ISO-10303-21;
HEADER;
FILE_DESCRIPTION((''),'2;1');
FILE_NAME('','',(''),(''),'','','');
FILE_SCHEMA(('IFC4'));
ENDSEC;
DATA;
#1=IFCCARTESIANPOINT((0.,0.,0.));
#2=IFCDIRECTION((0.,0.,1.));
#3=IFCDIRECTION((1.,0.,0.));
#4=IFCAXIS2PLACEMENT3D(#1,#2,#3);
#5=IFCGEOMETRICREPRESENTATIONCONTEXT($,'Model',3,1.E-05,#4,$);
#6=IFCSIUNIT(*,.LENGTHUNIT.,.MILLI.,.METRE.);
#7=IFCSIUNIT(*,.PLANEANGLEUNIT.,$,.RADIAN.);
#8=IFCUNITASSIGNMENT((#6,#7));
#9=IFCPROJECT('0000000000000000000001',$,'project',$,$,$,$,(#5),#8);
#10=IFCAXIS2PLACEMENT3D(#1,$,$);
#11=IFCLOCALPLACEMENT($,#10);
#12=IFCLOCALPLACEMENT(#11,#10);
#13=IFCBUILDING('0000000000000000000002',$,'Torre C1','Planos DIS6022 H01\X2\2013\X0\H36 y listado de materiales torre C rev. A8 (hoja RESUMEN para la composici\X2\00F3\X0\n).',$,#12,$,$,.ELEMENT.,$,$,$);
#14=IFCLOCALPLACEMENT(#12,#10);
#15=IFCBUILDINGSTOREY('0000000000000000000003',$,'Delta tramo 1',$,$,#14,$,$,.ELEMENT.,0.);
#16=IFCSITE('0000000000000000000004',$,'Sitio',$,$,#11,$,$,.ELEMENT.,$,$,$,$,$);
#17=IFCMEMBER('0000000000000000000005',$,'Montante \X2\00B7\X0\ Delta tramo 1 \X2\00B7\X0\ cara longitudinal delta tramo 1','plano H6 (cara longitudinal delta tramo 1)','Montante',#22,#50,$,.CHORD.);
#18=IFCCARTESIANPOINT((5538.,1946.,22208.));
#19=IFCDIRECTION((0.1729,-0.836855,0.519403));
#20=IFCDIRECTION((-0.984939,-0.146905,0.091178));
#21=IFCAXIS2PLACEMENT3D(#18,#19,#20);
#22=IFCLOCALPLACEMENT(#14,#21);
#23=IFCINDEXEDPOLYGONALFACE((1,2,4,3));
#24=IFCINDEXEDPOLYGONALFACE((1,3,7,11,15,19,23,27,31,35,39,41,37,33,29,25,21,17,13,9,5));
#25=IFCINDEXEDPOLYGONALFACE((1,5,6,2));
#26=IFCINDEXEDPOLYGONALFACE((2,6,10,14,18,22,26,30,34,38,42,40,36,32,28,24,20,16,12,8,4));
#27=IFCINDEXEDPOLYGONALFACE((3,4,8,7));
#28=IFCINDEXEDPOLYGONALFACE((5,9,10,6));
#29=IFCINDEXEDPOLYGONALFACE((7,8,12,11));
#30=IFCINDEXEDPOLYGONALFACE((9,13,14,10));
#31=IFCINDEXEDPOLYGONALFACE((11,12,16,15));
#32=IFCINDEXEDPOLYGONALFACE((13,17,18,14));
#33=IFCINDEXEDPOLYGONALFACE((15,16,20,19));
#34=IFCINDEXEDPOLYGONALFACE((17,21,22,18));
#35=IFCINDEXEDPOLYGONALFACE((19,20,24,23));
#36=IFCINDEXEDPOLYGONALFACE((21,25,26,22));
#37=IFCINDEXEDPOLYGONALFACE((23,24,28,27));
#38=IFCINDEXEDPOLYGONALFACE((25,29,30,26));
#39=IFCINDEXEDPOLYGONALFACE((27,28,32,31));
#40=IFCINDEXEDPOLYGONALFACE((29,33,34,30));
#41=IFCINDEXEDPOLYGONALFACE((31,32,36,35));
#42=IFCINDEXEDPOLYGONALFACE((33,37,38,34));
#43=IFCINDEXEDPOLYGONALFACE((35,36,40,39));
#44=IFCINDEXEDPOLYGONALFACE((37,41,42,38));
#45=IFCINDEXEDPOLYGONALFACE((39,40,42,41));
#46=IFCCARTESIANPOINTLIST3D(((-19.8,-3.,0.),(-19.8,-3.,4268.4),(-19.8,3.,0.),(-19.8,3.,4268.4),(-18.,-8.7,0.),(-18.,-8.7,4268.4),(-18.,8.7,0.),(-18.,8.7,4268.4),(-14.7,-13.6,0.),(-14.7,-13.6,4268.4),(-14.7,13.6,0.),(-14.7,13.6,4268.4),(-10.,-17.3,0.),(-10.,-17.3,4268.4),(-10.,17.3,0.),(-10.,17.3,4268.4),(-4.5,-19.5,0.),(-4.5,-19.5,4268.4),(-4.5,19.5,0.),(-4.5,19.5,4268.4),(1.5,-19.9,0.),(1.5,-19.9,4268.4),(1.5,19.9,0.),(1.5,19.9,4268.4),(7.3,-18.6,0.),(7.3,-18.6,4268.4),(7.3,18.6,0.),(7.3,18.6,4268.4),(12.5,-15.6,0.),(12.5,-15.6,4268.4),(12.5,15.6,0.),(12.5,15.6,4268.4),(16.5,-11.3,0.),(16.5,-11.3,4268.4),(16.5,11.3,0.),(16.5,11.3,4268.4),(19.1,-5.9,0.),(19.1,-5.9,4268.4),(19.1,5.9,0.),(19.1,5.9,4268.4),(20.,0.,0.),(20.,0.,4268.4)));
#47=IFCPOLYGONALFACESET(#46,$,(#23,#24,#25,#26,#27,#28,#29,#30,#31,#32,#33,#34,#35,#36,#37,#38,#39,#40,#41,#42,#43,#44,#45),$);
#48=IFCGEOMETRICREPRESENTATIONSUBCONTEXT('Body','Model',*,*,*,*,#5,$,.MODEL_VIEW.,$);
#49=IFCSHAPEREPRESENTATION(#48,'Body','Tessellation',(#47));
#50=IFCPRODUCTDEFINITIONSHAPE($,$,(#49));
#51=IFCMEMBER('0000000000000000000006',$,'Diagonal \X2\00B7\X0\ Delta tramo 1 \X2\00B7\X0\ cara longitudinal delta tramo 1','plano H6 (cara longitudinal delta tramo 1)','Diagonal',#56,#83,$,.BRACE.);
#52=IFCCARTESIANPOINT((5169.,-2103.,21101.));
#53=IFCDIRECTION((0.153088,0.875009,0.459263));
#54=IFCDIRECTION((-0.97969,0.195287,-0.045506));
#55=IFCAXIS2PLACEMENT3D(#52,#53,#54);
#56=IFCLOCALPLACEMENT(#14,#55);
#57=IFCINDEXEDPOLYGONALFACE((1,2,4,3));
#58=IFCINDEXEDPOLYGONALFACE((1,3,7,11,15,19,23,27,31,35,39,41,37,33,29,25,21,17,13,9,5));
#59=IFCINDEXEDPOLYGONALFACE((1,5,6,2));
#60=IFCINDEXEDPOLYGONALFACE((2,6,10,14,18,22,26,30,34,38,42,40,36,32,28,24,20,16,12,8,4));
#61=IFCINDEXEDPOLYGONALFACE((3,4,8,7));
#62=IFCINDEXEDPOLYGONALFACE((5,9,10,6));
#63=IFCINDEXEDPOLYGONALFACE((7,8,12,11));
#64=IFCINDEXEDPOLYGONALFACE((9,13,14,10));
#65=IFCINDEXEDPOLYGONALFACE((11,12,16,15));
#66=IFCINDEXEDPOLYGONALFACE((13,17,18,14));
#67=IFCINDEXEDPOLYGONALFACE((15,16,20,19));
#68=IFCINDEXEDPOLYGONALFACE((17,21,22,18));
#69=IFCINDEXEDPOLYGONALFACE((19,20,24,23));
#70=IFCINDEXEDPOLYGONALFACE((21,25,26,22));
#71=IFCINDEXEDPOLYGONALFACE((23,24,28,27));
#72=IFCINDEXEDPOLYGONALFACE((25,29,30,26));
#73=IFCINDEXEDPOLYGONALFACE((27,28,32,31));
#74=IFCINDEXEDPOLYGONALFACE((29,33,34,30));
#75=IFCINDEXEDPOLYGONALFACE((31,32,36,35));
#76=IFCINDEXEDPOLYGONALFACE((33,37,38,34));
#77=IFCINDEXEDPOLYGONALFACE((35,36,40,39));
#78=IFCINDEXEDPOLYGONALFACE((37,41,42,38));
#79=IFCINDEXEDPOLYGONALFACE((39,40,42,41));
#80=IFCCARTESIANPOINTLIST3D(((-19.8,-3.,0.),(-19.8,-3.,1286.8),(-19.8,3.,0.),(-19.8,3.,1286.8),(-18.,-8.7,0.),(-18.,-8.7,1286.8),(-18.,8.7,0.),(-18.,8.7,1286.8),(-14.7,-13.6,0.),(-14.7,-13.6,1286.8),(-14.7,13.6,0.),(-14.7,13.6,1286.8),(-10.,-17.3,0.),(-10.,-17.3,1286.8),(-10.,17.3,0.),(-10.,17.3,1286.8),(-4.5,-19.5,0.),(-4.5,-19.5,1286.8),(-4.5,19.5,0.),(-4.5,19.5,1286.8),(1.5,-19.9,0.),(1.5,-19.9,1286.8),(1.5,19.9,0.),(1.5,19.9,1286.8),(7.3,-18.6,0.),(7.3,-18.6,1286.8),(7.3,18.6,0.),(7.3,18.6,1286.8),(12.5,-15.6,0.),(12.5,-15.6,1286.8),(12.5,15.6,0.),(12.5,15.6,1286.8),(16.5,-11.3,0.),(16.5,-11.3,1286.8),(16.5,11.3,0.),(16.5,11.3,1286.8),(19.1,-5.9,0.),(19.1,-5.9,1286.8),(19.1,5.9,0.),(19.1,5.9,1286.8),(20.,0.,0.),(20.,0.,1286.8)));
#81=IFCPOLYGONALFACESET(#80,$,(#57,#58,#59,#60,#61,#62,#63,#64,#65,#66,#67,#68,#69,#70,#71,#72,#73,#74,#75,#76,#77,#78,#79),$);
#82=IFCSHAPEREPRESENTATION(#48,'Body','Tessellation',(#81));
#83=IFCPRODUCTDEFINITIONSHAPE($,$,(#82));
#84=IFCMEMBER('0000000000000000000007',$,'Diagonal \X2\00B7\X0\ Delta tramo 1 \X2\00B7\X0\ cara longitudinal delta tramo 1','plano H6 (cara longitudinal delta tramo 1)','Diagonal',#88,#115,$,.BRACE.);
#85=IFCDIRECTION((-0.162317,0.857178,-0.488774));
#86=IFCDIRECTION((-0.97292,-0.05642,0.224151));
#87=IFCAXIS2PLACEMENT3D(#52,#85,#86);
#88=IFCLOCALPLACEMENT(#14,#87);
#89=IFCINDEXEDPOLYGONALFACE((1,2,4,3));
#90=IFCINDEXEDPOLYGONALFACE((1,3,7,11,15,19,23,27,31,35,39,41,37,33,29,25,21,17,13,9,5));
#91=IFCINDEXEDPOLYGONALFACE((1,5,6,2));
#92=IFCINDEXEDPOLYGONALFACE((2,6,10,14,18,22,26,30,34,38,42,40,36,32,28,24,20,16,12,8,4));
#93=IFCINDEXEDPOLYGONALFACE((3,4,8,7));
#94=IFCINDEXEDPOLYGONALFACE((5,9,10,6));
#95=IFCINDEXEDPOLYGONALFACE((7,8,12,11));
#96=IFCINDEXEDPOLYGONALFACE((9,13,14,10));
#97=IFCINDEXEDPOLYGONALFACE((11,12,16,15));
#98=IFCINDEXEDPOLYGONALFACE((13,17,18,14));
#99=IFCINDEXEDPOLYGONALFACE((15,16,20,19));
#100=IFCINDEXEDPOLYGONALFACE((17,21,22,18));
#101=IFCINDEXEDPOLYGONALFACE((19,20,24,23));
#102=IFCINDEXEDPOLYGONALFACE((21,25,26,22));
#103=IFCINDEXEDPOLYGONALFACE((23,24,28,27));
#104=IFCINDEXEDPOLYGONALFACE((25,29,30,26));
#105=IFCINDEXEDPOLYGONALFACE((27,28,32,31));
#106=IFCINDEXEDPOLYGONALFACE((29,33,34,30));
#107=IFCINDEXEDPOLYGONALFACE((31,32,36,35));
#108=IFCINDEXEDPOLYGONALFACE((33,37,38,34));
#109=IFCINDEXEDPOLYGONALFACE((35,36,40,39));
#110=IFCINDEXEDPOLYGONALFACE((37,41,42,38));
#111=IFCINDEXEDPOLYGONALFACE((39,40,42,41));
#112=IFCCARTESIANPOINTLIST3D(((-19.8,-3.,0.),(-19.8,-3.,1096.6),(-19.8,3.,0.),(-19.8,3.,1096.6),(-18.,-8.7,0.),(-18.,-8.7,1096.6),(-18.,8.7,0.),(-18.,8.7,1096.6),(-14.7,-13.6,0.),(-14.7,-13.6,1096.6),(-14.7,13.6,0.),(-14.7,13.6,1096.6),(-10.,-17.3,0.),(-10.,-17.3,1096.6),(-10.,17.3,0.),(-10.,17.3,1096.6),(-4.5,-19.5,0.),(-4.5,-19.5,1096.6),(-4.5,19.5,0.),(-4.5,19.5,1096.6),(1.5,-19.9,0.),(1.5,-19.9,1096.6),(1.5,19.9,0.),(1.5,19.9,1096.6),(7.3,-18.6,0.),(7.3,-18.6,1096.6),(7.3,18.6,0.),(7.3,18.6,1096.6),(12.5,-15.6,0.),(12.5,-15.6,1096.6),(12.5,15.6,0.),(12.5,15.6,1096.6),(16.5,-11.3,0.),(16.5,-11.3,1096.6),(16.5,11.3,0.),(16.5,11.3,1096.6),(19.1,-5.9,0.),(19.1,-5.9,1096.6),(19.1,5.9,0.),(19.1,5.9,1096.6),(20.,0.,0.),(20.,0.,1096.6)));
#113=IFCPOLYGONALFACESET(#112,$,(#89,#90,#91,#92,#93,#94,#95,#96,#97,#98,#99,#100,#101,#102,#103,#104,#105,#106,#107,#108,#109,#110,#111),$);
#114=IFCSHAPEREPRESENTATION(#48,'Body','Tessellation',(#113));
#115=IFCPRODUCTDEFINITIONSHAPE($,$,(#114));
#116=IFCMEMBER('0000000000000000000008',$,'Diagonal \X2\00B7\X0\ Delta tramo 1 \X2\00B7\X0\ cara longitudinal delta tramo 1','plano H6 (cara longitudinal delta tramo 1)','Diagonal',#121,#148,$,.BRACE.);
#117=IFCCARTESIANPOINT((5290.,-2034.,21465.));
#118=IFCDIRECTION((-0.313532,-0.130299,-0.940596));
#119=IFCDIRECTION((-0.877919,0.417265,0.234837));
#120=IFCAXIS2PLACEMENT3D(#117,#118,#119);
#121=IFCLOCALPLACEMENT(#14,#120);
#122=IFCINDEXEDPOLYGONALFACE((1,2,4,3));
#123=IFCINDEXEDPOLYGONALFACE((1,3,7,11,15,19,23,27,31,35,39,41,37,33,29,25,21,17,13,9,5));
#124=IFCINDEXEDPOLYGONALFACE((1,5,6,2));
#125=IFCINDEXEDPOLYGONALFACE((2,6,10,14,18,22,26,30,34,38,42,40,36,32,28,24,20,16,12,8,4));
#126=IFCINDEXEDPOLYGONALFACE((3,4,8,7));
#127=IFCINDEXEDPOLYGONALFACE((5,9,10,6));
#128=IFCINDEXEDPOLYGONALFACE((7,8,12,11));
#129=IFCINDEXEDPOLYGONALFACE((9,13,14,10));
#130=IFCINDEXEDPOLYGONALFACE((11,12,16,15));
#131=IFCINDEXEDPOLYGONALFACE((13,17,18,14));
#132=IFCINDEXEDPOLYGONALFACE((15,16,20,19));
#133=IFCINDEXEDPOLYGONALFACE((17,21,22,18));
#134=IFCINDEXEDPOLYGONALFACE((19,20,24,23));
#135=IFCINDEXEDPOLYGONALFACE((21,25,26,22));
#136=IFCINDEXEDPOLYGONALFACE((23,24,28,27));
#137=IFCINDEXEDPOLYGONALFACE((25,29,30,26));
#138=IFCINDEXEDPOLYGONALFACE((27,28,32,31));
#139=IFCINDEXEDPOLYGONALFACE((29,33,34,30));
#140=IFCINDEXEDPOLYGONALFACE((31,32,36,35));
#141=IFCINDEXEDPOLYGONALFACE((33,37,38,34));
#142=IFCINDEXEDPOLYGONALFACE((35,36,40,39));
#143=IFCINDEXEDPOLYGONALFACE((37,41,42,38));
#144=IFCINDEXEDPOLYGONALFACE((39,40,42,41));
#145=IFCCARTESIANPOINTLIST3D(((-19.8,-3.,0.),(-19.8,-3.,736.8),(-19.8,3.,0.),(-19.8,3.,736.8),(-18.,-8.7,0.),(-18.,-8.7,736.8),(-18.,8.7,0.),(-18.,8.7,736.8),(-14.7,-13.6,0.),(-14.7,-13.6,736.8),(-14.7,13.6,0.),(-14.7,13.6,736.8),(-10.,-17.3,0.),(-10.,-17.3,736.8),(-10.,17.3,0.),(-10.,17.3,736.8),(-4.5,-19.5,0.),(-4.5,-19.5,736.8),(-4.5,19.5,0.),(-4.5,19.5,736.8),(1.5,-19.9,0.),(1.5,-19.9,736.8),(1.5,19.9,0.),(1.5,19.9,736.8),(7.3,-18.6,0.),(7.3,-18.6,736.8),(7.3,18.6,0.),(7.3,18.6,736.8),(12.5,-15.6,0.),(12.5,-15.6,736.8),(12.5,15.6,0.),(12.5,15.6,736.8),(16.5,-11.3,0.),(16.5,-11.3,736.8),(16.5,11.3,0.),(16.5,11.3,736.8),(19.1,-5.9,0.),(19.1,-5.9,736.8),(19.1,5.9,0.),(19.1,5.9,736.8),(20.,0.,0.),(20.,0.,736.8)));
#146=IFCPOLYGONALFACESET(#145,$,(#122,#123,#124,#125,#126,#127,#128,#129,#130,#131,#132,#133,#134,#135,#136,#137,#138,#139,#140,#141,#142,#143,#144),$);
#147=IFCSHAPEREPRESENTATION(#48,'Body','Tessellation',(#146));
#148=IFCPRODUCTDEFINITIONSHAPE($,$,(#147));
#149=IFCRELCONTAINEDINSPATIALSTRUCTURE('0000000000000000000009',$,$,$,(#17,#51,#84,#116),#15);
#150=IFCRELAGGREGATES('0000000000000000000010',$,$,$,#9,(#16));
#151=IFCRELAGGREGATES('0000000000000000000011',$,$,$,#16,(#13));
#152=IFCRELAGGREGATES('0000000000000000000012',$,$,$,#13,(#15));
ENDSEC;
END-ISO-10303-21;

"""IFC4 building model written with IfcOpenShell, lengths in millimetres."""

from ifc_helpers import new_model, si_unit, frame, origin, origin_with_axes, place, context, subcontext, project, spatial, circle, extrude, element, save


model = new_model("IFC4")

# Units and contexts
model_context = context("Model", 3, precision=1e-05, world=origin_with_axes())
body_context = subcontext(model_context, "Body", "Model", "MODEL_VIEW")
ifc_project = project(units=[si_unit("LENGTHUNIT", "METRE", prefix="MILLI"), si_unit("PLANEANGLEUNIT", "RADIAN")], contexts=[model_context])

# Site, building, storey
site_placement = place(None, origin())
site = spatial("IfcSite", under=ifc_project, at=site_placement, Name="Sitio", CompositionType="ELEMENT")
building_placement = place(site_placement, origin())
building = spatial("IfcBuilding", under=site, at=building_placement, Name="Torre C1", Description="Planos DIS6022 H01–H36 y listado de materiales torre C rev. A8 (hoja RESUMEN para la composición).", CompositionType="ELEMENT")
storey_placement = place(building_placement, origin())
storey = spatial("IfcBuildingStorey", under=building, at=storey_placement, Name="Delta tramo 1", CompositionType="ELEMENT", Elevation=0.0)

# Members
member_1_placement = place(storey_placement, frame((5538.0, 1946.0, 22208.0), z_axis=(0.1729, -0.836855, 0.519403), x_axis=(-0.984939, -0.146905, 0.091178)))
element("IfcMember", 1, at=member_1_placement, inside=storey, Name="Montante · Delta tramo 1 · cara longitudinal delta tramo 1", Description="plano H6 (cara longitudinal delta tramo 1)", ObjectType="Montante", PredefinedType="CHORD", context=body_context, shape_type="SweptSolid", body=[
    extrude(circle(Radius=20.0), None, (0.0, 0.0, 1.0), 4268.4),
])
member_2_placement = place(storey_placement, frame((5169.0, -2103.0, 21101.0), z_axis=(0.153088, 0.875009, 0.459263), x_axis=(-0.97969, 0.195287, -0.045506)))
element("IfcMember", 2, at=member_2_placement, inside=storey, Name="Diagonal · Delta tramo 1 · cara longitudinal delta tramo 1", Description="plano H6 (cara longitudinal delta tramo 1)", ObjectType="Diagonal", PredefinedType="BRACE", context=body_context, shape_type="SweptSolid", body=[
    extrude(circle(Radius=20.0), None, (0.0, 0.0, 1.0), 1286.8),
])
member_3_placement = place(storey_placement, frame((5169.0, -2103.0, 21101.0), z_axis=(-0.162317, 0.857178, -0.488774), x_axis=(-0.97292, -0.05642, 0.224151)))
element("IfcMember", 3, at=member_3_placement, inside=storey, Name="Diagonal · Delta tramo 1 · cara longitudinal delta tramo 1", Description="plano H6 (cara longitudinal delta tramo 1)", ObjectType="Diagonal", PredefinedType="BRACE", context=body_context, shape_type="SweptSolid", body=[
    extrude(circle(Radius=20.0), None, (0.0, 0.0, 1.0), 1096.6),
])
member_4_placement = place(storey_placement, frame((5290.0, -2034.0, 21465.0), z_axis=(-0.313532, -0.130299, -0.940596), x_axis=(-0.877919, 0.417265, 0.234837)))
element("IfcMember", 4, at=member_4_placement, inside=storey, Name="Diagonal · Delta tramo 1 · cara longitudinal delta tramo 1", Description="plano H6 (cara longitudinal delta tramo 1)", ObjectType="Diagonal", PredefinedType="BRACE", context=body_context, shape_type="SweptSolid", body=[
    extrude(circle(Radius=20.0), None, (0.0, 0.0, 1.0), 736.8),
])

save(model, "model.ifc")
